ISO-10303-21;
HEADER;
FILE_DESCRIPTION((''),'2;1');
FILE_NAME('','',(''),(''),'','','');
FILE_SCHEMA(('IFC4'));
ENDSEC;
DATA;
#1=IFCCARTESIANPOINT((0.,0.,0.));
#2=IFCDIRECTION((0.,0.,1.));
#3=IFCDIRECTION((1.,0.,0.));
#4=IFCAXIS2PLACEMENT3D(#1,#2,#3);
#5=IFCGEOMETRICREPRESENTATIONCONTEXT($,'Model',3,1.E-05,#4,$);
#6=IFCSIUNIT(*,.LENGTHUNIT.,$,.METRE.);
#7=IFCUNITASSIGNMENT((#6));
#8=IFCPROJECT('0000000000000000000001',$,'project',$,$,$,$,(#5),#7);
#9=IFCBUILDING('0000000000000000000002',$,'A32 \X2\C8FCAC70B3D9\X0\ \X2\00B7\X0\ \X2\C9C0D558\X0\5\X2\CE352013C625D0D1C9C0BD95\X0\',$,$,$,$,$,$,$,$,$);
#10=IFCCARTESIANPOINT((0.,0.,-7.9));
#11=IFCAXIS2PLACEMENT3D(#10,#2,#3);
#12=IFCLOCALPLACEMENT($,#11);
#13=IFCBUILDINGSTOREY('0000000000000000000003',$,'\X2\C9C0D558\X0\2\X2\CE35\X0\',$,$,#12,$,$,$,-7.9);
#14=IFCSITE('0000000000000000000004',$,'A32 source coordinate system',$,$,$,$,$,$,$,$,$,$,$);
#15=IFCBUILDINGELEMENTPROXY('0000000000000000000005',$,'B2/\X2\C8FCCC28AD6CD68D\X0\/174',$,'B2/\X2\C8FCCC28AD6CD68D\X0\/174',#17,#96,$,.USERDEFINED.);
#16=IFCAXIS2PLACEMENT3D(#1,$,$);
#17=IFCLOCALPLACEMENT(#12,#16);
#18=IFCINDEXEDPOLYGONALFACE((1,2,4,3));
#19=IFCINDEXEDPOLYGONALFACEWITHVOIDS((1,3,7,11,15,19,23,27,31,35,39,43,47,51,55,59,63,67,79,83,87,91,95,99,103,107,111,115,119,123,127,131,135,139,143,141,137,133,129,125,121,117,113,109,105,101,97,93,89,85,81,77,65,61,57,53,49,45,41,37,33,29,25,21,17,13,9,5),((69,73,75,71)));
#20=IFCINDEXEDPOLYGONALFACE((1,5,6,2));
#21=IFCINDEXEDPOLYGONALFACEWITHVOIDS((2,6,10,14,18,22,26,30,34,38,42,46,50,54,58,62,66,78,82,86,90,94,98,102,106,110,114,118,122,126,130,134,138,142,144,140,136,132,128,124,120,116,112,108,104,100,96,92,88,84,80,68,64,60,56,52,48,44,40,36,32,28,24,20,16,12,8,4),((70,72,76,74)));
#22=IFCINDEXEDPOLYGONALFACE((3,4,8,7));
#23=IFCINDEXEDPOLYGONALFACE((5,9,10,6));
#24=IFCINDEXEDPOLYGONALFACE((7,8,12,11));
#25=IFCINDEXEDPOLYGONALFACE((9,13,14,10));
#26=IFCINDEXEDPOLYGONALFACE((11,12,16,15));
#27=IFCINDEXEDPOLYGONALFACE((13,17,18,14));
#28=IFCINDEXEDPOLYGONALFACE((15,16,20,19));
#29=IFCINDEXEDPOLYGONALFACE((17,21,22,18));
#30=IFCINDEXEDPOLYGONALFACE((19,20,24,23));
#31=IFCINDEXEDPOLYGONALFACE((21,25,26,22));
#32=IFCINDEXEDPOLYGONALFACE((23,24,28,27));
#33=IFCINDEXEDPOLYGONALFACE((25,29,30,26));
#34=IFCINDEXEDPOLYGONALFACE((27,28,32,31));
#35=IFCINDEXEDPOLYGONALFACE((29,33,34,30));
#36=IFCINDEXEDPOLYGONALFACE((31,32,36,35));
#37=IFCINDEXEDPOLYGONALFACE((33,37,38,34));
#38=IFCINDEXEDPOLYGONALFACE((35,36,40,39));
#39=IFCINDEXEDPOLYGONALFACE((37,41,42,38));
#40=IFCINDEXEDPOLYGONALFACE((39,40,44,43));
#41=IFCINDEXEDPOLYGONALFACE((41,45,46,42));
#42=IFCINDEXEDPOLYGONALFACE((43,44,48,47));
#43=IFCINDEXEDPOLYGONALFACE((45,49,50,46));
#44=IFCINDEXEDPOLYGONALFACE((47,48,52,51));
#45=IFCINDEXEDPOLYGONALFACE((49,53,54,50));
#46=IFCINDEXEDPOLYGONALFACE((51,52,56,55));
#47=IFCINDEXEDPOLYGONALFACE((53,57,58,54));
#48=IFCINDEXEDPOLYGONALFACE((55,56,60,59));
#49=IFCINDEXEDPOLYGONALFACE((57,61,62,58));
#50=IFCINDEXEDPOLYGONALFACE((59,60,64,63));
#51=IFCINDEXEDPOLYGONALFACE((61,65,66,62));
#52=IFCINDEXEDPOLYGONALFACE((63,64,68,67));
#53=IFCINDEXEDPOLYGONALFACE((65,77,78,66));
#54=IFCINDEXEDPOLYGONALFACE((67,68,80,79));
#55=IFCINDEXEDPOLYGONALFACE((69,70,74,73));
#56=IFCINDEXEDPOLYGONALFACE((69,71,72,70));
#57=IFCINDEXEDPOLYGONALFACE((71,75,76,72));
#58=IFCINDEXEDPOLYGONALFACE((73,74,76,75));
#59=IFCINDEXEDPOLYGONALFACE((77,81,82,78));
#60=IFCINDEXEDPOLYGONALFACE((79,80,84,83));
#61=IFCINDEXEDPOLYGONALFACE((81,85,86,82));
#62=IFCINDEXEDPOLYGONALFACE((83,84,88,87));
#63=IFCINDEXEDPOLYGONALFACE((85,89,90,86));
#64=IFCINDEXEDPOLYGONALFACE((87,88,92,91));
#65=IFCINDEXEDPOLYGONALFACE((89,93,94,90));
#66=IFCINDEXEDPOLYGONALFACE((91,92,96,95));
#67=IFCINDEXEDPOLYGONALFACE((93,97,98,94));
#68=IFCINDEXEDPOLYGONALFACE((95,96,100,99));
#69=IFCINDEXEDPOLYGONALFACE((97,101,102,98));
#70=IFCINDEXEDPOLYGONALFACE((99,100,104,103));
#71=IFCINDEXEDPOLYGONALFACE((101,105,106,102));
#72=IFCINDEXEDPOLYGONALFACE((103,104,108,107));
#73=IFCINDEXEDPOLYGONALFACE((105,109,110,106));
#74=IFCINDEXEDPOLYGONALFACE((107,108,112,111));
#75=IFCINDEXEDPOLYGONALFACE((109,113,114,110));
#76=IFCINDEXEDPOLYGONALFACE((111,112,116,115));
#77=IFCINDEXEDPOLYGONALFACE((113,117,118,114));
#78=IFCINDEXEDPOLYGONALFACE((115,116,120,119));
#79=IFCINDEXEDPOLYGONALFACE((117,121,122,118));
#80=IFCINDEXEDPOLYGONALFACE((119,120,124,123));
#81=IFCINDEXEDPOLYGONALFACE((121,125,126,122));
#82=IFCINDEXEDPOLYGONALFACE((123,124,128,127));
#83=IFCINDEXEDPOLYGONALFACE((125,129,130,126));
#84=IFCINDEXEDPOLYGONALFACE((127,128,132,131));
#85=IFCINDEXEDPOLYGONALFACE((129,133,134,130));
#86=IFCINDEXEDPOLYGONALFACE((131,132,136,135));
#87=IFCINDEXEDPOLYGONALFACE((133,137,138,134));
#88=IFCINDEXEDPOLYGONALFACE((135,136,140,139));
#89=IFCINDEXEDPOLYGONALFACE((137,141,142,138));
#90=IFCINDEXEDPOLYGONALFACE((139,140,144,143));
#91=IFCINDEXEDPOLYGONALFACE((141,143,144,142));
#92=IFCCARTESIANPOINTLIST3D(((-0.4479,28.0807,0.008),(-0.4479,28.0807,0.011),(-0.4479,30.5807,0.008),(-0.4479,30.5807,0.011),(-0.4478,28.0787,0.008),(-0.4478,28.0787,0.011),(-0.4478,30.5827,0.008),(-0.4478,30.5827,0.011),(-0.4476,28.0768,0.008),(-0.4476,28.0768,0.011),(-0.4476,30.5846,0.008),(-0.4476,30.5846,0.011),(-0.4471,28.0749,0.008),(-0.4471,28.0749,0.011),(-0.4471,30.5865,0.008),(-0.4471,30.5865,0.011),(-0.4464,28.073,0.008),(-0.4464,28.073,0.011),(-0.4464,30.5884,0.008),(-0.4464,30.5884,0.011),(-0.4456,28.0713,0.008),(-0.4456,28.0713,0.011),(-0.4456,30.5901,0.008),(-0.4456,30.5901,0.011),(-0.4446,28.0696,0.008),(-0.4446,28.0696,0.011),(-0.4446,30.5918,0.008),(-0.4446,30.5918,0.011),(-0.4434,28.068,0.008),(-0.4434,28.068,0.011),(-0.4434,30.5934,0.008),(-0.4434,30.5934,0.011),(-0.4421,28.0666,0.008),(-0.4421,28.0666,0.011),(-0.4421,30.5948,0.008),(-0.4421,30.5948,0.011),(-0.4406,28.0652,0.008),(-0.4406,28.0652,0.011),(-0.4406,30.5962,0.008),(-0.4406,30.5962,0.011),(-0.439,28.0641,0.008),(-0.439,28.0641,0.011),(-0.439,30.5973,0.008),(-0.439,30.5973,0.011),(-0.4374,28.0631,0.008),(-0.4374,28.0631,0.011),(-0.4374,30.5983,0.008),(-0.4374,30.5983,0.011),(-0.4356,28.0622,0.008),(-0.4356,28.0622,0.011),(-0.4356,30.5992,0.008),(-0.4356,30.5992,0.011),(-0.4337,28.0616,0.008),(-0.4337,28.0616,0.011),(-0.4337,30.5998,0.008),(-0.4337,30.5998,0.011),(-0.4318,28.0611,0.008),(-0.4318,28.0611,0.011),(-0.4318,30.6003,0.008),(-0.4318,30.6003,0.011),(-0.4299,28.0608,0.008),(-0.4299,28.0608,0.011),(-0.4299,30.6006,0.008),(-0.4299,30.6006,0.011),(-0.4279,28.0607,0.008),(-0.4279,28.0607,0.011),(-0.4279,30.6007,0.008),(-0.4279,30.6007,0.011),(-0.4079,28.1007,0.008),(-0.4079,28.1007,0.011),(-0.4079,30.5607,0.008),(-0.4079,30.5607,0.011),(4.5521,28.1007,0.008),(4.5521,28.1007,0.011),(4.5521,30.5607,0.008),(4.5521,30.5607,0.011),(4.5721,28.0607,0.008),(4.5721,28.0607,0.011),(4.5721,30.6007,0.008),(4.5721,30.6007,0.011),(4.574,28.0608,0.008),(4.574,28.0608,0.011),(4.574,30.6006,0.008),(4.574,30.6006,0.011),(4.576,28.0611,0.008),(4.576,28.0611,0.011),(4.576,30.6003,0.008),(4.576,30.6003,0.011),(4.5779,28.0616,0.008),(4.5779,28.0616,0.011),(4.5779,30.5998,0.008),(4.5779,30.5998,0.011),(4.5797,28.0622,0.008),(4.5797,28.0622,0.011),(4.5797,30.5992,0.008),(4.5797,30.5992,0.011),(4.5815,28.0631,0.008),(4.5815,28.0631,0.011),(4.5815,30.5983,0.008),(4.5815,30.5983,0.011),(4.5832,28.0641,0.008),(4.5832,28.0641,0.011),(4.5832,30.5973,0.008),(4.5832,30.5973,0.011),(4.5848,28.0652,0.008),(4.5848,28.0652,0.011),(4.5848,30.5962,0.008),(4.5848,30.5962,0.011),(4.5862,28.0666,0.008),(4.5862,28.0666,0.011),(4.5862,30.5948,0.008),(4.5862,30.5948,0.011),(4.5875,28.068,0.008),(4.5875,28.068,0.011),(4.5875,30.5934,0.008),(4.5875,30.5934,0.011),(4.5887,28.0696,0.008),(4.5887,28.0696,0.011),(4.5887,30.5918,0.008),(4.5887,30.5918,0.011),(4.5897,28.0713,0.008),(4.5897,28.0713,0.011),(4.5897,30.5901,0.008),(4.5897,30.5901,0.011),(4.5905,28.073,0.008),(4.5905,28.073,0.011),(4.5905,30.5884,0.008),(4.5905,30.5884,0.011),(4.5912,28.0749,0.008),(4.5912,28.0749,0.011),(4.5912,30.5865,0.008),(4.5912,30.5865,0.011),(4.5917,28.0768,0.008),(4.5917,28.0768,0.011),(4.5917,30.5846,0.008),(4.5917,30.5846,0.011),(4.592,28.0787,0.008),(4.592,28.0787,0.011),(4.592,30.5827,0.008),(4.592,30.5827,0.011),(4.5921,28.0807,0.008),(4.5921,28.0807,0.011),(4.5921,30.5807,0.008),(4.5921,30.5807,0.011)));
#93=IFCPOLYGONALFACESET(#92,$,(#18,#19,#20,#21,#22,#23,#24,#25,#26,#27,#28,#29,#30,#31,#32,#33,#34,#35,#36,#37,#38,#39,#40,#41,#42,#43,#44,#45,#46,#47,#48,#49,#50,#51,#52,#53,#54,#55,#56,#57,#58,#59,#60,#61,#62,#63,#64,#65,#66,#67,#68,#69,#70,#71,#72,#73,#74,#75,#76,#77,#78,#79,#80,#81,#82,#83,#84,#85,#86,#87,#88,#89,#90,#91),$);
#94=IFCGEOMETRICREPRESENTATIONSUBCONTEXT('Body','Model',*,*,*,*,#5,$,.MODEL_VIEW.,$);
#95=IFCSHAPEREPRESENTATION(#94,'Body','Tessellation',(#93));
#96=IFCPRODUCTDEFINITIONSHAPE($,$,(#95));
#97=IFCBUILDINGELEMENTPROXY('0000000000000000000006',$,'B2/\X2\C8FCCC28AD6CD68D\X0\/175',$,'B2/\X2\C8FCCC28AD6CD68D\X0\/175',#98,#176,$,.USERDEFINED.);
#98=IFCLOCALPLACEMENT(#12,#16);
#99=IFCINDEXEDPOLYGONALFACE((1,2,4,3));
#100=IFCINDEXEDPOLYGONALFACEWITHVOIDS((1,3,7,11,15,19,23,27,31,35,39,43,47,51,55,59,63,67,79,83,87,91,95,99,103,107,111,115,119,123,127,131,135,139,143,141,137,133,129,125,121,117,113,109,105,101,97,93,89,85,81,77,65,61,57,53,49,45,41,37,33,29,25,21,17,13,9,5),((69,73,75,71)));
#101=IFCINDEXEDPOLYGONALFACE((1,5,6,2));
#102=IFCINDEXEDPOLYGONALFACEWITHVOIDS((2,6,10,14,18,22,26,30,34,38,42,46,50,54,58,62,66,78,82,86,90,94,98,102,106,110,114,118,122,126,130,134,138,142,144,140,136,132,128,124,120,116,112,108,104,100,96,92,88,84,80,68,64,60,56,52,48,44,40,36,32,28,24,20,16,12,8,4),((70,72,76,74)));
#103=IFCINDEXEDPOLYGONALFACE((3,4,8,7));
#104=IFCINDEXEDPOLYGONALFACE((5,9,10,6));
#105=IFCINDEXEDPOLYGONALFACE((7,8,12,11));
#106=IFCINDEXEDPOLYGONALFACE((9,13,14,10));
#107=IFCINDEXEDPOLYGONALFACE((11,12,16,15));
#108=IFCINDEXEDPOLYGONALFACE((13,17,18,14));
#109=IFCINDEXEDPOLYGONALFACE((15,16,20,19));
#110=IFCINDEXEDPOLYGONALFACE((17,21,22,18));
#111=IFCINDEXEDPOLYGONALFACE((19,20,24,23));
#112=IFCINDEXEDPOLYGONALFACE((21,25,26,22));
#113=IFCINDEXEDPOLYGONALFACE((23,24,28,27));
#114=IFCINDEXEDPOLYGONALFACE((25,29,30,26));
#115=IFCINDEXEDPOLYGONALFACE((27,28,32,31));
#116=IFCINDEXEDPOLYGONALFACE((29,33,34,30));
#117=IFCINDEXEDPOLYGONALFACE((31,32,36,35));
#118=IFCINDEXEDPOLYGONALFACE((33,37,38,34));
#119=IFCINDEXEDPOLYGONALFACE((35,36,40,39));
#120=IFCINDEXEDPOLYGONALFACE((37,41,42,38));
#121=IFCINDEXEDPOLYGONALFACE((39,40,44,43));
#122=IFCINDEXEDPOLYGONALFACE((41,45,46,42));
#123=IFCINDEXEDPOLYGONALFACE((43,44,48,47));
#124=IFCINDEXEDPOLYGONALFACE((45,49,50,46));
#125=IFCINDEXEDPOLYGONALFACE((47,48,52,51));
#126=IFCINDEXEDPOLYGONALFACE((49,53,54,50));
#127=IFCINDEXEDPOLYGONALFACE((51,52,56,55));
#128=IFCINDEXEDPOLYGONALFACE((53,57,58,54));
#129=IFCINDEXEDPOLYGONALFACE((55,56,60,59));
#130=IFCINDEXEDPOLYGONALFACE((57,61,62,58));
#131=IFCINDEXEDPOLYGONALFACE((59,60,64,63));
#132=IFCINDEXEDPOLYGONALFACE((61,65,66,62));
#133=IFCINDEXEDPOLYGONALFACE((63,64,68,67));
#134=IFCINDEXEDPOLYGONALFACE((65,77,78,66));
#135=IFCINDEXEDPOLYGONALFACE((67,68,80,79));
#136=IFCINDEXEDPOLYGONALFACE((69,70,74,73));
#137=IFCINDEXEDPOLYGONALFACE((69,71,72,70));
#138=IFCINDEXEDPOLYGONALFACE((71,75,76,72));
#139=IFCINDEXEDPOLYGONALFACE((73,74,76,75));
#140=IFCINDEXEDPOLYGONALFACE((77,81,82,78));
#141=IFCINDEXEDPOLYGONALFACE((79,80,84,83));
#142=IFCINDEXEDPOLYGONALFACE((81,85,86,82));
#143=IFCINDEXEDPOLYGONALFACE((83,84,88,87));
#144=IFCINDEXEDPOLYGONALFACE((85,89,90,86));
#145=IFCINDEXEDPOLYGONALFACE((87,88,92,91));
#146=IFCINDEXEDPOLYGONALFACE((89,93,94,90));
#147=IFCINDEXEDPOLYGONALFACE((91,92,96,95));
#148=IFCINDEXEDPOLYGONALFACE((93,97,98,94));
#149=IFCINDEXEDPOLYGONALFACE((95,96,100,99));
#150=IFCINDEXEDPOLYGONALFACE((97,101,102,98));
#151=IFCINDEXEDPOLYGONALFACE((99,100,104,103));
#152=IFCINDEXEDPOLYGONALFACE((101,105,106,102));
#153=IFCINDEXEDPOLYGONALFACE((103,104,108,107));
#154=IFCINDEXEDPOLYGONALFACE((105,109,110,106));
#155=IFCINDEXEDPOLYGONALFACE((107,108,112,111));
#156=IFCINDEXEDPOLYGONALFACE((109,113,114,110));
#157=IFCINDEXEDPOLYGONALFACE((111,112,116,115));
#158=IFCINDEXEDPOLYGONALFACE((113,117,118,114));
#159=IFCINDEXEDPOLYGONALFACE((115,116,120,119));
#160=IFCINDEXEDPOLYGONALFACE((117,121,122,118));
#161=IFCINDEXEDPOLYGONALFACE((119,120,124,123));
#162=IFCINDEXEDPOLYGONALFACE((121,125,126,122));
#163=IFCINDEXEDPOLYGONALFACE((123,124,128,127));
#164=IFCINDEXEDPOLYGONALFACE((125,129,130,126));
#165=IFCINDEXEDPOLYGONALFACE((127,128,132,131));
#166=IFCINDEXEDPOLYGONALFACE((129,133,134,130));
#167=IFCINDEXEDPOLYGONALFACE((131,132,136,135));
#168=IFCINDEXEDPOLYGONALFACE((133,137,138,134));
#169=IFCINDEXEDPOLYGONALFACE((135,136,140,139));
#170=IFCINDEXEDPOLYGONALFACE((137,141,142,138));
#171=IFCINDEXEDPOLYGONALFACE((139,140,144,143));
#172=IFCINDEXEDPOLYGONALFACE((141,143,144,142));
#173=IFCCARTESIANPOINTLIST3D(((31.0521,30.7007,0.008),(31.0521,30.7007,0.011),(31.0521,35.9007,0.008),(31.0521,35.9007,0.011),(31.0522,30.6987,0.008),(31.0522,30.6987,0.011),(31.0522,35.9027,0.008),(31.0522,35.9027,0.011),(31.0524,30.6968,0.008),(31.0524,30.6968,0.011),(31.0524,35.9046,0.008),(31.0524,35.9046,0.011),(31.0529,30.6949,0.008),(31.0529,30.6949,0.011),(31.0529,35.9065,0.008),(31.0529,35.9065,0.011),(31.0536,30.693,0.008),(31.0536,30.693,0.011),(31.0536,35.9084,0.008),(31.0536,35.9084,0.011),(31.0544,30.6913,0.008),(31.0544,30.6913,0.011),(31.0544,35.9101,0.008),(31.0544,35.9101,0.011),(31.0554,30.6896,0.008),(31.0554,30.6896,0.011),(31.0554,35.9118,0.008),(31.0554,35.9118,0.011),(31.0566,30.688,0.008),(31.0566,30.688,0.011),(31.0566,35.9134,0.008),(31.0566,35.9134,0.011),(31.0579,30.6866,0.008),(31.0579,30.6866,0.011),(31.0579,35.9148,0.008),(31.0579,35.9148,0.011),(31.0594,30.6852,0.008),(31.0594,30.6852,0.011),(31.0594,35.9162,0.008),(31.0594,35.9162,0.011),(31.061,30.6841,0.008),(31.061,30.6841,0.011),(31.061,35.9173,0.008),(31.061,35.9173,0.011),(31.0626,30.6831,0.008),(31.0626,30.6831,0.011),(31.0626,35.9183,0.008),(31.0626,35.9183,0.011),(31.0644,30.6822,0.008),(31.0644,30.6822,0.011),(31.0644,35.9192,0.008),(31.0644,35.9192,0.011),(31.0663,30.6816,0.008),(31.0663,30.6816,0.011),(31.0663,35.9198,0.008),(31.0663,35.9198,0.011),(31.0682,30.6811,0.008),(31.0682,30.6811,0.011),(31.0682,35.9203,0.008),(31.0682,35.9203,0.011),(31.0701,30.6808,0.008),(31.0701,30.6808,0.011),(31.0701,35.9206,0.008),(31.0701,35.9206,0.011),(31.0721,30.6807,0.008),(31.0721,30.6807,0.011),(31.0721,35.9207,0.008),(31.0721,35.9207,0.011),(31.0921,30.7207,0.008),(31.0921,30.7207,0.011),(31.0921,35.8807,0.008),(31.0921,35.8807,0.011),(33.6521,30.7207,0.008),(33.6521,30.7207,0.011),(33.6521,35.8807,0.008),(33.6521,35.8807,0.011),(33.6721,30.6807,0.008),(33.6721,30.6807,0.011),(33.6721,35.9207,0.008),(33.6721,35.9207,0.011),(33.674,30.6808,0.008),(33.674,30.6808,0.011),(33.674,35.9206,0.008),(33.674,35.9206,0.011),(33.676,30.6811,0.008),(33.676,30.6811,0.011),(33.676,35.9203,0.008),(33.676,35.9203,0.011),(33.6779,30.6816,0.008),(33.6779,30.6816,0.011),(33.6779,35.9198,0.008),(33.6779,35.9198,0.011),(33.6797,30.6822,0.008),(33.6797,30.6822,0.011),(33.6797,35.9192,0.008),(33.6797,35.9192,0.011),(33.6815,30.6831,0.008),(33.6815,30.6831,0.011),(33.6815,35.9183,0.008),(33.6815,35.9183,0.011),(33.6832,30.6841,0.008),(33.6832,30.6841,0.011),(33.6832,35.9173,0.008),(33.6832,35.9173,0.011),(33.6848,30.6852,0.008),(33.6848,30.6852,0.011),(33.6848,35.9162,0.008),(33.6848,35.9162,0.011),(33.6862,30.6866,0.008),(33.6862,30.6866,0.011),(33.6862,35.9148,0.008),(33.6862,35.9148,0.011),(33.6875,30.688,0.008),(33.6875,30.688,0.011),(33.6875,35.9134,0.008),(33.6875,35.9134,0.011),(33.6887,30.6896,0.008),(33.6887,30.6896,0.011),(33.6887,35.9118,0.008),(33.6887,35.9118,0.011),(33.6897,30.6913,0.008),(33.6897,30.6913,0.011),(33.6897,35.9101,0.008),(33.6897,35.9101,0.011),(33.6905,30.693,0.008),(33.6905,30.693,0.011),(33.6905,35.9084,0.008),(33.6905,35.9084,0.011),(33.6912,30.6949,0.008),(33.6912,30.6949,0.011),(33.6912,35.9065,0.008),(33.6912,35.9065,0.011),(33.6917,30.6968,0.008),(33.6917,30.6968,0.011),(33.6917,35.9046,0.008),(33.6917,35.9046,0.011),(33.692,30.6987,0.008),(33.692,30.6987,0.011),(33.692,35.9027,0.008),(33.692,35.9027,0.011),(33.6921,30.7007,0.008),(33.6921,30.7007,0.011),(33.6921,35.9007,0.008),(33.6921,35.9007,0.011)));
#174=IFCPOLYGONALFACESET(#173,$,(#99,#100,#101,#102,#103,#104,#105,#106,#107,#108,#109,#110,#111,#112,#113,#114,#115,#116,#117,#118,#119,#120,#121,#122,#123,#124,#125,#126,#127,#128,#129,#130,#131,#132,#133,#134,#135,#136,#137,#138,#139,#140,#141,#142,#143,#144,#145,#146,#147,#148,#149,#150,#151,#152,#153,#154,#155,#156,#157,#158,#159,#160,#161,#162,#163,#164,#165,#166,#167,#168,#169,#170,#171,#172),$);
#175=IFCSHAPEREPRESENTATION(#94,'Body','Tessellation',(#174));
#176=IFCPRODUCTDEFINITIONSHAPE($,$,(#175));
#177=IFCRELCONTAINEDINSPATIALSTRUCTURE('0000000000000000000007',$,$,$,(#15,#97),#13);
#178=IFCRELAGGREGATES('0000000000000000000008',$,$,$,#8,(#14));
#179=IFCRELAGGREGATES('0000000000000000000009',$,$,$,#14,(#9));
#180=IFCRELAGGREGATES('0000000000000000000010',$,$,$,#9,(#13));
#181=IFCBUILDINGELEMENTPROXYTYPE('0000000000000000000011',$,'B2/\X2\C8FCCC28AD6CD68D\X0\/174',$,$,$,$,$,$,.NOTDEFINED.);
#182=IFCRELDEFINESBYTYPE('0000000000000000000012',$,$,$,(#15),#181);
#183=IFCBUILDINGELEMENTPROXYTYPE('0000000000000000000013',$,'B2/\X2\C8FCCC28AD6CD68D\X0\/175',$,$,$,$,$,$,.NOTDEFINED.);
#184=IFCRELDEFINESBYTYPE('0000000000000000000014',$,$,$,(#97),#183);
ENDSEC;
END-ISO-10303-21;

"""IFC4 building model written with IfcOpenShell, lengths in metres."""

from ifc_helpers import new_model, si_unit, frame, origin, origin_with_axes, place, context, subcontext, project, spatial, polyline, outline, extrude, source, transform, mapped, type_object, type_shapes, element, save


model = new_model("IFC4")

# Units and contexts
model_context = context("Model", 3, precision=1e-05, world=origin_with_axes())
body_context = subcontext(model_context, "Body", "Model", "MODEL_VIEW")
ifc_project = project(units=[si_unit("LENGTHUNIT", "METRE")], contexts=[model_context])

# Site, building, storey
site = spatial("IfcSite", under=ifc_project, Name="A32 source coordinate system")
building = spatial("IfcBuilding", under=site, Name="A32 주거동 · 지하5층–옥탑지붕")
storey_placement = place(None, frame((0.0, 0.0, -7.9), z_axis=(0.0, 0.0, 1.0), x_axis=(1.0, 0.0, 0.0)))
storey = spatial("IfcBuildingStorey", under=building, at=storey_placement, Name="지하2층", Elevation=-7.9)

# Building element proxies
building_element_proxy_type_1 = type_object("IfcBuildingElementProxyType", Name="B2/주차구획/174", PredefinedType="NOTDEFINED")
shared_shape_1 = source(origin(), body_context, "Body", "SweptSolid", [
    extrude(outline(polyline([(-0.4279, 28.0607), (-0.4299, 28.0608), (-0.4318, 28.0611), (-0.4337, 28.0616), (-0.4356, 28.0622), (-0.4374, 28.0631), (-0.439, 28.0641), (-0.4406, 28.0652), (-0.4421, 28.0666), (-0.4434, 28.068), (-0.4446, 28.0696), (-0.4456, 28.0713), (-0.4464, 28.073), (-0.4471, 28.0749), (-0.4476, 28.0768), (-0.4478, 28.0787), (-0.4479, 28.0807), (-0.4479, 30.5807), (-0.4478, 30.5827), (-0.4476, 30.5846), (-0.4471, 30.5865), (-0.4464, 30.5884), (-0.4456, 30.5901), (-0.4446, 30.5918), (-0.4434, 30.5934), (-0.4421, 30.5948), (-0.4406, 30.5962), (-0.439, 30.5973), (-0.4374, 30.5983), (-0.4356, 30.5992), (-0.4337, 30.5998), (-0.4318, 30.6003), (-0.4299, 30.6006), (-0.4279, 30.6007), (4.5721, 30.6007), (4.574, 30.6006), (4.576, 30.6003), (4.5779, 30.5998), (4.5797, 30.5992), (4.5815, 30.5983), (4.5832, 30.5973), (4.5848, 30.5962), (4.5862, 30.5948), (4.5875, 30.5934), (4.5887, 30.5918), (4.5897, 30.5901), (4.5905, 30.5884), (4.5912, 30.5865), (4.5917, 30.5846), (4.592, 30.5827), (4.5921, 30.5807), (4.5921, 28.0807), (4.592, 28.0787), (4.5917, 28.0768), (4.5912, 28.0749), (4.5905, 28.073), (4.5897, 28.0713), (4.5887, 28.0696), (4.5875, 28.068), (4.5862, 28.0666), (4.5848, 28.0652), (4.5832, 28.0641), (4.5815, 28.0631), (4.5797, 28.0622), (4.5779, 28.0616), (4.576, 28.0611), (4.574, 28.0608), (4.5721, 28.0607), (-0.4279, 28.0607)]), holes=[polyline([(-0.4079, 28.1007), (4.5521, 28.1007), (4.5521, 30.5607), (-0.4079, 30.5607), (-0.4079, 28.1007)])]), frame((0.0, 0.0, 0.008)), (0.0, 0.0, 1.0), 0.003),
])
type_shapes(building_element_proxy_type_1, [shared_shape_1])
proxy_1_placement = place(storey_placement, origin_with_axes())
element("IfcBuildingElementProxy", 1, at=proxy_1_placement, inside=storey, type_object=building_element_proxy_type_1, Name="B2/주차구획/174", ObjectType="B2/주차구획/174", PredefinedType="USERDEFINED", context=body_context, shape_type="MappedRepresentation", body=[
    mapped(shared_shape_1, transform((0.0, 0.0, 0.0), scale=1.0)),
])
building_element_proxy_type_2 = type_object("IfcBuildingElementProxyType", Name="B2/주차구획/175", PredefinedType="NOTDEFINED")
shared_shape_2 = source(origin(), body_context, "Body", "SweptSolid", [
    extrude(outline(polyline([(31.0521, 35.9007), (31.0522, 35.9027), (31.0524, 35.9046), (31.0529, 35.9065), (31.0536, 35.9084), (31.0544, 35.9101), (31.0554, 35.9118), (31.0566, 35.9134), (31.0579, 35.9148), (31.0594, 35.9162), (31.061, 35.9173), (31.0626, 35.9183), (31.0644, 35.9192), (31.0663, 35.9198), (31.0682, 35.9203), (31.0701, 35.9206), (31.0721, 35.9207), (33.6721, 35.9207), (33.674, 35.9206), (33.676, 35.9203), (33.6779, 35.9198), (33.6797, 35.9192), (33.6815, 35.9183), (33.6832, 35.9173), (33.6848, 35.9162), (33.6862, 35.9148), (33.6875, 35.9134), (33.6887, 35.9118), (33.6897, 35.9101), (33.6905, 35.9084), (33.6912, 35.9065), (33.6917, 35.9046), (33.692, 35.9027), (33.6921, 35.9007), (33.6921, 30.7007), (33.692, 30.6987), (33.6917, 30.6968), (33.6912, 30.6949), (33.6905, 30.693), (33.6897, 30.6913), (33.6887, 30.6896), (33.6875, 30.688), (33.6862, 30.6866), (33.6848, 30.6852), (33.6832, 30.6841), (33.6815, 30.6831), (33.6797, 30.6822), (33.6779, 30.6816), (33.676, 30.6811), (33.674, 30.6808), (33.6721, 30.6807), (31.0721, 30.6807), (31.0701, 30.6808), (31.0682, 30.6811), (31.0663, 30.6816), (31.0644, 30.6822), (31.0626, 30.6831), (31.061, 30.6841), (31.0594, 30.6852), (31.0579, 30.6866), (31.0566, 30.688), (31.0554, 30.6896), (31.0544, 30.6913), (31.0536, 30.693), (31.0529, 30.6949), (31.0524, 30.6968), (31.0522, 30.6987), (31.0521, 30.7007), (31.0521, 35.9007)]), holes=[polyline([(31.0921, 35.8807), (31.0921, 30.7207), (33.6521, 30.7207), (33.6521, 35.8807), (31.0921, 35.8807)])]), frame((0.0, 0.0, 0.008)), (0.0, 0.0, 1.0), 0.003),
])
type_shapes(building_element_proxy_type_2, [shared_shape_2])
proxy_2_placement = place(storey_placement, origin_with_axes())
element("IfcBuildingElementProxy", 2, at=proxy_2_placement, inside=storey, type_object=building_element_proxy_type_2, Name="B2/주차구획/175", ObjectType="B2/주차구획/175", PredefinedType="USERDEFINED", context=body_context, shape_type="MappedRepresentation", body=[
    mapped(shared_shape_2, transform((0.0, 0.0, 0.0), scale=1.0)),
])

save(model, "model.ifc")
